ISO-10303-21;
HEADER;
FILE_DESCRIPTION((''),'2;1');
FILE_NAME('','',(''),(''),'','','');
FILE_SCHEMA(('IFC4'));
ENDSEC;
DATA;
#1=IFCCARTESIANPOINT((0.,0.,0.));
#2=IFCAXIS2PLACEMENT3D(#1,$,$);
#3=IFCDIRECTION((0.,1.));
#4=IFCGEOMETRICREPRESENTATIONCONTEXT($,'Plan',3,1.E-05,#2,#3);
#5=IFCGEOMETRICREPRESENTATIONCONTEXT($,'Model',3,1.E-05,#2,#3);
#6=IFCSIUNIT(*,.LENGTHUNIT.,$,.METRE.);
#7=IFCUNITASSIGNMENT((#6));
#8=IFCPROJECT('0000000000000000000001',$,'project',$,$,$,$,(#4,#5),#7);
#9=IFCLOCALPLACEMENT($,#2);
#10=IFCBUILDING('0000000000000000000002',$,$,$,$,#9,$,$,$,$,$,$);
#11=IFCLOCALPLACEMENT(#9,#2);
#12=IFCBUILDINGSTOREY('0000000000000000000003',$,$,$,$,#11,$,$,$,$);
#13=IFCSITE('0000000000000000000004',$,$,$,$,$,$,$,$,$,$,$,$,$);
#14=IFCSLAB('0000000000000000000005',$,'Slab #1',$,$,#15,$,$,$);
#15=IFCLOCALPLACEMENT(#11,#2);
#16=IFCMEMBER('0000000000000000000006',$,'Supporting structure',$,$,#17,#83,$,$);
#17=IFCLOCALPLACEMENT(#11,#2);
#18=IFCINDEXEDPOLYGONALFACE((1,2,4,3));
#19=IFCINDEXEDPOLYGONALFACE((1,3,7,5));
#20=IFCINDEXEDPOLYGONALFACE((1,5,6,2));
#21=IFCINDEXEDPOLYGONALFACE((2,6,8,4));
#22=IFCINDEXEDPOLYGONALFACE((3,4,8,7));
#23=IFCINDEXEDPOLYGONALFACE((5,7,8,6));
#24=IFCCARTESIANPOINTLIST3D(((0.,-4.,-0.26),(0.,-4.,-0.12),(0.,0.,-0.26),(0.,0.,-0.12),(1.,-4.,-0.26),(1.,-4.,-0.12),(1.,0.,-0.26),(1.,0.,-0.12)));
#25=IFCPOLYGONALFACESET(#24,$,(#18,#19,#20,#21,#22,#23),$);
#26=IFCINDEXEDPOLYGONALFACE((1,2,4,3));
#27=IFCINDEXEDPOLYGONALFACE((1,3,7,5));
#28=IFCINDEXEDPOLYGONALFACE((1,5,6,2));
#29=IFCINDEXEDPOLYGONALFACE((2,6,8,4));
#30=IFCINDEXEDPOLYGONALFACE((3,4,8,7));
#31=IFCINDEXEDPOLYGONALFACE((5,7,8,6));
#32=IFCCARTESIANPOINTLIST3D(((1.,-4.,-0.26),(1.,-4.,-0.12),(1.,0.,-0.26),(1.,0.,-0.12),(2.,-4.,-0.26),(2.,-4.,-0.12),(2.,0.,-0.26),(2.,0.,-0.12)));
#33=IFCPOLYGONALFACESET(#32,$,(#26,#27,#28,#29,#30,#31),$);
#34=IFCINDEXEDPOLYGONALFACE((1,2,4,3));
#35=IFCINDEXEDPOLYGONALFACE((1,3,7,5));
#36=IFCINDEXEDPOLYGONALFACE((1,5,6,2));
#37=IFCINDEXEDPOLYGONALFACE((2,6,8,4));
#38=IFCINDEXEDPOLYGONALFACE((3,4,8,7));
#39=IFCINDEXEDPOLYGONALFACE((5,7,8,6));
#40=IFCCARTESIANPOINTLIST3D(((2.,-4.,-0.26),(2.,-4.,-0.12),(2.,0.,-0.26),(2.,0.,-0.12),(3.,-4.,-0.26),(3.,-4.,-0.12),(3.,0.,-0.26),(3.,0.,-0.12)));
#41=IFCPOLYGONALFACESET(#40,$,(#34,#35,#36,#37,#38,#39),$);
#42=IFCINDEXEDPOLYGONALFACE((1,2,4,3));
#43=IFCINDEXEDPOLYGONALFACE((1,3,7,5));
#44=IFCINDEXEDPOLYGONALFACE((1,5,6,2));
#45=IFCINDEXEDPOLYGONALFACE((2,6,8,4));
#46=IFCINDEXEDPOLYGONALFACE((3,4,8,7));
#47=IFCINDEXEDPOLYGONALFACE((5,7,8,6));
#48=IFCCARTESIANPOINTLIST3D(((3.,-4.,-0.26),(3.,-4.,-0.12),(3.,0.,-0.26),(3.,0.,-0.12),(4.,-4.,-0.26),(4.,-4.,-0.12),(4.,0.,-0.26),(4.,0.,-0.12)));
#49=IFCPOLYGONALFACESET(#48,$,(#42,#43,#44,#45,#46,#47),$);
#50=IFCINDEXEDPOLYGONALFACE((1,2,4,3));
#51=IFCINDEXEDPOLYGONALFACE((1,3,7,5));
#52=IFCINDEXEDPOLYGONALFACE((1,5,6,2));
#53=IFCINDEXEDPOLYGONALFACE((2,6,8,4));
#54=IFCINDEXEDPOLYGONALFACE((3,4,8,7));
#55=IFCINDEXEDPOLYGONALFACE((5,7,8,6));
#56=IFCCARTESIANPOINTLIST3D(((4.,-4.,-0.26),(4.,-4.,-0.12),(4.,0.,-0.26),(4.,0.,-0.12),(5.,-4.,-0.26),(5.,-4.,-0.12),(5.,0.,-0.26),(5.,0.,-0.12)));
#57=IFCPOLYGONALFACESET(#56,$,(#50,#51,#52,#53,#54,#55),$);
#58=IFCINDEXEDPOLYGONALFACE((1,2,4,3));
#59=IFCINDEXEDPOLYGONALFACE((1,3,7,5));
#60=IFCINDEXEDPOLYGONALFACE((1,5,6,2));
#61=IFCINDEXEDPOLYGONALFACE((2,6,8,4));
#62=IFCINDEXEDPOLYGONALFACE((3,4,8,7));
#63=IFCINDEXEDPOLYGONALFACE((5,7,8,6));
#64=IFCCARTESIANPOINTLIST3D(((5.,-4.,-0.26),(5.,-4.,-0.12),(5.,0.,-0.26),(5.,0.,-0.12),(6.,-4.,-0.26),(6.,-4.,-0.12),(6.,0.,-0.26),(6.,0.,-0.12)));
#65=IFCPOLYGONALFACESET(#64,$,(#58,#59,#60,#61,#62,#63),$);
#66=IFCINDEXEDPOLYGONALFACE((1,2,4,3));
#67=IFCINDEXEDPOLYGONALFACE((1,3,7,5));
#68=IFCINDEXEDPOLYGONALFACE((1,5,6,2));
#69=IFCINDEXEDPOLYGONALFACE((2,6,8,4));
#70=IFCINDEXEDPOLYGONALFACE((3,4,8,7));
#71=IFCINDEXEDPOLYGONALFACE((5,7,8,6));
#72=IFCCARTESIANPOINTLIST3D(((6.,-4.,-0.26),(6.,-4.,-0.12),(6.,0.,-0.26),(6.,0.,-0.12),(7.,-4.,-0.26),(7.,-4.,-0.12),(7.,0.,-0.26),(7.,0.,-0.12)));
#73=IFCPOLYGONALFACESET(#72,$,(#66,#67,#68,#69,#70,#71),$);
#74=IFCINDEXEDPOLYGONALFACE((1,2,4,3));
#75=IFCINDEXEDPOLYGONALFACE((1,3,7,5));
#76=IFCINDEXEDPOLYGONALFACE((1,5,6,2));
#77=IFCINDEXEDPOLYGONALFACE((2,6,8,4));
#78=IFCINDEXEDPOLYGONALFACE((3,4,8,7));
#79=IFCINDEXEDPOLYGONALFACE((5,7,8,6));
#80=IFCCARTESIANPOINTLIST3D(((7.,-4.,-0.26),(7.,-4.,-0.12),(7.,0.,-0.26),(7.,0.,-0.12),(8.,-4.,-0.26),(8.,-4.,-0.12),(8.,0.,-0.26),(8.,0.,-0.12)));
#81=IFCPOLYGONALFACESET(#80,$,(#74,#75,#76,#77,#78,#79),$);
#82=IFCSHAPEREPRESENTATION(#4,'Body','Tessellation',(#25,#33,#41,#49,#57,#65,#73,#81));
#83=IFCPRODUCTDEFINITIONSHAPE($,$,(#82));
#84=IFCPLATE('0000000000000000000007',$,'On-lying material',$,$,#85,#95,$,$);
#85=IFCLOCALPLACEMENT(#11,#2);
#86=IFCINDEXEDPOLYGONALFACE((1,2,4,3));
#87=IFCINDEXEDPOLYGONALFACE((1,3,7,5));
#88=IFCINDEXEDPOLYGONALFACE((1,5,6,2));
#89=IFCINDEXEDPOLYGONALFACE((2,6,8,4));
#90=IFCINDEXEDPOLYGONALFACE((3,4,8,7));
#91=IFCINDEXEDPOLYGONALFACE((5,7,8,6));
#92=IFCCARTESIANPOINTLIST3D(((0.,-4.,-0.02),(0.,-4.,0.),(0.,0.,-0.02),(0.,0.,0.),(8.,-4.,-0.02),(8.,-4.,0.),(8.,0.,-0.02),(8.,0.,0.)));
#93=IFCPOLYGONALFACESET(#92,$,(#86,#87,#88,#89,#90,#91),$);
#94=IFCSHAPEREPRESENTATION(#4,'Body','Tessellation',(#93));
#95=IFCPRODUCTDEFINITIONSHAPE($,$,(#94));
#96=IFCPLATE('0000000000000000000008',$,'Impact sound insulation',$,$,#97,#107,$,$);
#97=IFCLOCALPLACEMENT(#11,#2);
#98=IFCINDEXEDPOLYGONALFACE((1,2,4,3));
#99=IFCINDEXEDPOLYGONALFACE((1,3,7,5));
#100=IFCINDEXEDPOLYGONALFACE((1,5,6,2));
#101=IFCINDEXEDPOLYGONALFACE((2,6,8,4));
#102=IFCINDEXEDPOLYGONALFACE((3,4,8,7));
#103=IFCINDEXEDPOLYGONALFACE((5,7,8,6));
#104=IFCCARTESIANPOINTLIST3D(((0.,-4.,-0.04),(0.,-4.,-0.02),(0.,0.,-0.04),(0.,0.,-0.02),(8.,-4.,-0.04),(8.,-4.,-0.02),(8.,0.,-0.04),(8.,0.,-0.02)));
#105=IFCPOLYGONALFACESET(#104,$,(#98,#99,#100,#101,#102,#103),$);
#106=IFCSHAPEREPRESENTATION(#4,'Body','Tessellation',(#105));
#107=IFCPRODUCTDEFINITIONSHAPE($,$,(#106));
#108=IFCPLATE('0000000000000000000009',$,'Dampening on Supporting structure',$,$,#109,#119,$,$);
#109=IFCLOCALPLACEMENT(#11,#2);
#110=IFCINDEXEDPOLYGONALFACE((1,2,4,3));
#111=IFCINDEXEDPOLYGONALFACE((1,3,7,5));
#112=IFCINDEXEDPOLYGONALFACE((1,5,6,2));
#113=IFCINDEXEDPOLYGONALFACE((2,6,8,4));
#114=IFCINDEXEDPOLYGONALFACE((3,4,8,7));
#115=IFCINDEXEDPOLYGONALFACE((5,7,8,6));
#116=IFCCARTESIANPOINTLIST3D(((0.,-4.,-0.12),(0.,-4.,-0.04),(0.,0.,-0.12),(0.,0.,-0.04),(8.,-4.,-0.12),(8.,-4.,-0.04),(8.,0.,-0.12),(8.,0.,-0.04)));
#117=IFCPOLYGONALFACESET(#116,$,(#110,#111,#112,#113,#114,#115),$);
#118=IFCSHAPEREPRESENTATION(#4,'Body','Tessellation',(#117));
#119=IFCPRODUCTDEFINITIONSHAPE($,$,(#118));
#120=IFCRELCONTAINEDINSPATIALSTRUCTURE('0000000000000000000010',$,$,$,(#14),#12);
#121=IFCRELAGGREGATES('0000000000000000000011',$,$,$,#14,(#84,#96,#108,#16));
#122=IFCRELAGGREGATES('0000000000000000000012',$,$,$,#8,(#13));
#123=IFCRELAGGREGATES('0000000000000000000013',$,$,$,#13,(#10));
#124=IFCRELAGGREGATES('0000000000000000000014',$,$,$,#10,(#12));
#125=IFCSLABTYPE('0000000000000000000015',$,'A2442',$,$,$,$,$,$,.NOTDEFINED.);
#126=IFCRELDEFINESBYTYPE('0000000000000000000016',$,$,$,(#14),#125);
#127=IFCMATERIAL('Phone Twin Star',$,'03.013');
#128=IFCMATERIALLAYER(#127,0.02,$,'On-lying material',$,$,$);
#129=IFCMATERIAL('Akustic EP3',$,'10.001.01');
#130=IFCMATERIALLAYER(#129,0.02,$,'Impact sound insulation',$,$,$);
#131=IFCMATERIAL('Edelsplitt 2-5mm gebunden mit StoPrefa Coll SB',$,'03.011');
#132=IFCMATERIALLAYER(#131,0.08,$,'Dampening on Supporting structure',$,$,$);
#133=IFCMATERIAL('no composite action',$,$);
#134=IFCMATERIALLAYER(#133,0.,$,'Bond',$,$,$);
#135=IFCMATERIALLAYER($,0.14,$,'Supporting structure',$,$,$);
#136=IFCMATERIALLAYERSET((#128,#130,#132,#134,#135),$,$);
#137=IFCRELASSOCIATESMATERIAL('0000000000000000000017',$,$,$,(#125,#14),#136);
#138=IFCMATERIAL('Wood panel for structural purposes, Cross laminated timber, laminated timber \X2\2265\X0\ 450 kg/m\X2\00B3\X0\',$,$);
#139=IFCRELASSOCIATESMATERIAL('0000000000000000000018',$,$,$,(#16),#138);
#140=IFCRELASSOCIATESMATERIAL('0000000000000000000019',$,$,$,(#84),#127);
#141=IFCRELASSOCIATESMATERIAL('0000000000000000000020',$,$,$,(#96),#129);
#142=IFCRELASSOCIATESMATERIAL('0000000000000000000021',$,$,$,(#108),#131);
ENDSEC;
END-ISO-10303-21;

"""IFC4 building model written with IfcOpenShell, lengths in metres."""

from ifc_helpers import new_model, si_unit, direction, frame, frame_2d, origin, origin_with_axes, place, context, project, spatial, rectangle, extrude, material, layer, layer_set, type_object, element, aggregate, save


model = new_model("IFC4")

# Units and contexts
plan_context = context("Plan", 3, precision=1e-05, world=origin(), true_north=direction((0.0, 1.0)))
model_context = context("Model", 3, precision=1e-05, world=origin(), true_north=direction((0.0, 1.0)))
ifc_project = project(units=[si_unit("LENGTHUNIT", "METRE")], contexts=[plan_context, model_context])

# Site, building, storey
site = spatial("IfcSite", under=ifc_project)
building_placement = place(None, origin())
building = spatial("IfcBuilding", under=site, at=building_placement)
storey_placement = place(building_placement, origin())
storey = spatial("IfcBuildingStorey", under=building, at=storey_placement)

# Slab, member, plates
ifc_material_1 = material(Name="Phone Twin Star", Category="03.013")
ifc_layer_1 = layer(ifc_material_1, 0.02, Name="On-lying material")
ifc_material_2 = material(Name="Akustic EP3", Category="10.001.01")
ifc_layer_2 = layer(ifc_material_2, 0.02, Name="Impact sound insulation")
ifc_material_3 = material(Name="Edelsplitt 2-5mm gebunden mit StoPrefa Coll SB", Category="03.011")
ifc_layer_3 = layer(ifc_material_3, 0.08, Name="Dampening on Supporting structure")
ifc_material_4 = material(Name="no composite action")
ifc_layer_4 = layer(ifc_material_4, 0.0, Name="Bond")
ifc_layer_5 = layer(None, 0.14, Name="Supporting structure")
ifc_layer_set = layer_set([ifc_layer_1, ifc_layer_2, ifc_layer_3, ifc_layer_4, ifc_layer_5])
slab_type = type_object("IfcSlabType", Name="A2442", PredefinedType="NOTDEFINED", material=ifc_layer_set)
slab_placement = place(None, frame((0.0, 0.0, 0.0), z_axis=(0.0, 0.0, -1.0), x_axis=(1.0, 0.0, 0.0)))
slab = element("IfcSlab", 1, at=slab_placement, inside=storey, type_object=slab_type, material=ifc_layer_set, Name="Slab #1")
ifc_material_5 = material(Name="Wood panel for structural purposes, Cross laminated timber, laminated timber ≥ 450 kg/m³")
member_placement = place(slab_placement, origin())
member = element("IfcMember", 2, at=member_placement, material=ifc_material_5, Name="Supporting structure", context=plan_context, shape_type="SweptSolid", body=[
    extrude(rectangle(XDim=1.0, YDim=0.14, at=frame_2d((0.5, 0.07), x_axis=(1.0, 0.0))), frame((0.0, 4.0, 0.12), z_axis=(0.0, -1.0, 0.0), x_axis=(1.0, 0.0, 0.0)), (0.0, 0.0, 1.0), 4.0),
    extrude(rectangle(XDim=1.0, YDim=0.14, at=frame_2d((0.5, 0.07), x_axis=(1.0, 0.0))), frame((1.0, 4.0, 0.12), z_axis=(0.0, -1.0, 0.0), x_axis=(1.0, 0.0, 0.0)), (0.0, 0.0, 1.0), 4.0),
    extrude(rectangle(XDim=1.0, YDim=0.14, at=frame_2d((0.5, 0.07), x_axis=(1.0, 0.0))), frame((2.0, 4.0, 0.12), z_axis=(0.0, -1.0, 0.0), x_axis=(1.0, 0.0, 0.0)), (0.0, 0.0, 1.0), 4.0),
    extrude(rectangle(XDim=1.0, YDim=0.14, at=frame_2d((0.5, 0.07), x_axis=(1.0, 0.0))), frame((3.0, 4.0, 0.12), z_axis=(0.0, -1.0, 0.0), x_axis=(1.0, 0.0, 0.0)), (0.0, 0.0, 1.0), 4.0),
    extrude(rectangle(XDim=1.0, YDim=0.14, at=frame_2d((0.5, 0.07), x_axis=(1.0, 0.0))), frame((4.0, 4.0, 0.12), z_axis=(0.0, -1.0, 0.0), x_axis=(1.0, 0.0, 0.0)), (0.0, 0.0, 1.0), 4.0),
    extrude(rectangle(XDim=1.0, YDim=0.14, at=frame_2d((0.5, 0.07), x_axis=(1.0, 0.0))), frame((5.0, 4.0, 0.12), z_axis=(0.0, -1.0, 0.0), x_axis=(1.0, 0.0, 0.0)), (0.0, 0.0, 1.0), 4.0),
    extrude(rectangle(XDim=1.0, YDim=0.14, at=frame_2d((0.5, 0.07), x_axis=(1.0, 0.0))), frame((6.0, 4.0, 0.12), z_axis=(0.0, -1.0, 0.0), x_axis=(1.0, 0.0, 0.0)), (0.0, 0.0, 1.0), 4.0),
    extrude(rectangle(XDim=1.0, YDim=0.14, at=frame_2d((0.5, 0.07), x_axis=(1.0, 0.0))), frame((7.0, 4.0, 0.12), z_axis=(0.0, -1.0, 0.0), x_axis=(1.0, 0.0, 0.0)), (0.0, 0.0, 1.0), 4.0),
])
plate_1_placement = place(slab_placement, origin())
plate_1 = element("IfcPlate", 3, at=plate_1_placement, material=ifc_material_1, Name="On-lying material", context=plan_context, shape_type="SweptSolid", body=[
    extrude(rectangle(XDim=8.0, YDim=4.0, at=frame_2d((4.0, 2.0), x_axis=(1.0, 0.0))), origin_with_axes(), (0.0, 0.0, 1.0), 0.02),
])
plate_2_placement = place(slab_placement, origin())
plate_2 = element("IfcPlate", 4, at=plate_2_placement, material=ifc_material_2, Name="Impact sound insulation", context=plan_context, shape_type="SweptSolid", body=[
    extrude(rectangle(XDim=8.0, YDim=4.0, at=frame_2d((4.0, 2.0), x_axis=(1.0, 0.0))), frame((0.0, 0.0, 0.02), z_axis=(0.0, 0.0, 1.0), x_axis=(1.0, 0.0, 0.0)), (0.0, 0.0, 1.0), 0.02),
])
plate_3_placement = place(slab_placement, origin())
plate_3 = element("IfcPlate", 5, at=plate_3_placement, material=ifc_material_3, Name="Dampening on Supporting structure", context=plan_context, shape_type="SweptSolid", body=[
    extrude(rectangle(XDim=8.0, YDim=4.0, at=frame_2d((4.0, 2.0), x_axis=(1.0, 0.0))), frame((0.0, 0.0, 0.04), z_axis=(0.0, 0.0, 1.0), x_axis=(1.0, 0.0, 0.0)), (0.0, 0.0, 1.0), 0.08),
])
aggregate(slab, [plate_1, plate_2, plate_3, member])

save(model, "model.ifc")
